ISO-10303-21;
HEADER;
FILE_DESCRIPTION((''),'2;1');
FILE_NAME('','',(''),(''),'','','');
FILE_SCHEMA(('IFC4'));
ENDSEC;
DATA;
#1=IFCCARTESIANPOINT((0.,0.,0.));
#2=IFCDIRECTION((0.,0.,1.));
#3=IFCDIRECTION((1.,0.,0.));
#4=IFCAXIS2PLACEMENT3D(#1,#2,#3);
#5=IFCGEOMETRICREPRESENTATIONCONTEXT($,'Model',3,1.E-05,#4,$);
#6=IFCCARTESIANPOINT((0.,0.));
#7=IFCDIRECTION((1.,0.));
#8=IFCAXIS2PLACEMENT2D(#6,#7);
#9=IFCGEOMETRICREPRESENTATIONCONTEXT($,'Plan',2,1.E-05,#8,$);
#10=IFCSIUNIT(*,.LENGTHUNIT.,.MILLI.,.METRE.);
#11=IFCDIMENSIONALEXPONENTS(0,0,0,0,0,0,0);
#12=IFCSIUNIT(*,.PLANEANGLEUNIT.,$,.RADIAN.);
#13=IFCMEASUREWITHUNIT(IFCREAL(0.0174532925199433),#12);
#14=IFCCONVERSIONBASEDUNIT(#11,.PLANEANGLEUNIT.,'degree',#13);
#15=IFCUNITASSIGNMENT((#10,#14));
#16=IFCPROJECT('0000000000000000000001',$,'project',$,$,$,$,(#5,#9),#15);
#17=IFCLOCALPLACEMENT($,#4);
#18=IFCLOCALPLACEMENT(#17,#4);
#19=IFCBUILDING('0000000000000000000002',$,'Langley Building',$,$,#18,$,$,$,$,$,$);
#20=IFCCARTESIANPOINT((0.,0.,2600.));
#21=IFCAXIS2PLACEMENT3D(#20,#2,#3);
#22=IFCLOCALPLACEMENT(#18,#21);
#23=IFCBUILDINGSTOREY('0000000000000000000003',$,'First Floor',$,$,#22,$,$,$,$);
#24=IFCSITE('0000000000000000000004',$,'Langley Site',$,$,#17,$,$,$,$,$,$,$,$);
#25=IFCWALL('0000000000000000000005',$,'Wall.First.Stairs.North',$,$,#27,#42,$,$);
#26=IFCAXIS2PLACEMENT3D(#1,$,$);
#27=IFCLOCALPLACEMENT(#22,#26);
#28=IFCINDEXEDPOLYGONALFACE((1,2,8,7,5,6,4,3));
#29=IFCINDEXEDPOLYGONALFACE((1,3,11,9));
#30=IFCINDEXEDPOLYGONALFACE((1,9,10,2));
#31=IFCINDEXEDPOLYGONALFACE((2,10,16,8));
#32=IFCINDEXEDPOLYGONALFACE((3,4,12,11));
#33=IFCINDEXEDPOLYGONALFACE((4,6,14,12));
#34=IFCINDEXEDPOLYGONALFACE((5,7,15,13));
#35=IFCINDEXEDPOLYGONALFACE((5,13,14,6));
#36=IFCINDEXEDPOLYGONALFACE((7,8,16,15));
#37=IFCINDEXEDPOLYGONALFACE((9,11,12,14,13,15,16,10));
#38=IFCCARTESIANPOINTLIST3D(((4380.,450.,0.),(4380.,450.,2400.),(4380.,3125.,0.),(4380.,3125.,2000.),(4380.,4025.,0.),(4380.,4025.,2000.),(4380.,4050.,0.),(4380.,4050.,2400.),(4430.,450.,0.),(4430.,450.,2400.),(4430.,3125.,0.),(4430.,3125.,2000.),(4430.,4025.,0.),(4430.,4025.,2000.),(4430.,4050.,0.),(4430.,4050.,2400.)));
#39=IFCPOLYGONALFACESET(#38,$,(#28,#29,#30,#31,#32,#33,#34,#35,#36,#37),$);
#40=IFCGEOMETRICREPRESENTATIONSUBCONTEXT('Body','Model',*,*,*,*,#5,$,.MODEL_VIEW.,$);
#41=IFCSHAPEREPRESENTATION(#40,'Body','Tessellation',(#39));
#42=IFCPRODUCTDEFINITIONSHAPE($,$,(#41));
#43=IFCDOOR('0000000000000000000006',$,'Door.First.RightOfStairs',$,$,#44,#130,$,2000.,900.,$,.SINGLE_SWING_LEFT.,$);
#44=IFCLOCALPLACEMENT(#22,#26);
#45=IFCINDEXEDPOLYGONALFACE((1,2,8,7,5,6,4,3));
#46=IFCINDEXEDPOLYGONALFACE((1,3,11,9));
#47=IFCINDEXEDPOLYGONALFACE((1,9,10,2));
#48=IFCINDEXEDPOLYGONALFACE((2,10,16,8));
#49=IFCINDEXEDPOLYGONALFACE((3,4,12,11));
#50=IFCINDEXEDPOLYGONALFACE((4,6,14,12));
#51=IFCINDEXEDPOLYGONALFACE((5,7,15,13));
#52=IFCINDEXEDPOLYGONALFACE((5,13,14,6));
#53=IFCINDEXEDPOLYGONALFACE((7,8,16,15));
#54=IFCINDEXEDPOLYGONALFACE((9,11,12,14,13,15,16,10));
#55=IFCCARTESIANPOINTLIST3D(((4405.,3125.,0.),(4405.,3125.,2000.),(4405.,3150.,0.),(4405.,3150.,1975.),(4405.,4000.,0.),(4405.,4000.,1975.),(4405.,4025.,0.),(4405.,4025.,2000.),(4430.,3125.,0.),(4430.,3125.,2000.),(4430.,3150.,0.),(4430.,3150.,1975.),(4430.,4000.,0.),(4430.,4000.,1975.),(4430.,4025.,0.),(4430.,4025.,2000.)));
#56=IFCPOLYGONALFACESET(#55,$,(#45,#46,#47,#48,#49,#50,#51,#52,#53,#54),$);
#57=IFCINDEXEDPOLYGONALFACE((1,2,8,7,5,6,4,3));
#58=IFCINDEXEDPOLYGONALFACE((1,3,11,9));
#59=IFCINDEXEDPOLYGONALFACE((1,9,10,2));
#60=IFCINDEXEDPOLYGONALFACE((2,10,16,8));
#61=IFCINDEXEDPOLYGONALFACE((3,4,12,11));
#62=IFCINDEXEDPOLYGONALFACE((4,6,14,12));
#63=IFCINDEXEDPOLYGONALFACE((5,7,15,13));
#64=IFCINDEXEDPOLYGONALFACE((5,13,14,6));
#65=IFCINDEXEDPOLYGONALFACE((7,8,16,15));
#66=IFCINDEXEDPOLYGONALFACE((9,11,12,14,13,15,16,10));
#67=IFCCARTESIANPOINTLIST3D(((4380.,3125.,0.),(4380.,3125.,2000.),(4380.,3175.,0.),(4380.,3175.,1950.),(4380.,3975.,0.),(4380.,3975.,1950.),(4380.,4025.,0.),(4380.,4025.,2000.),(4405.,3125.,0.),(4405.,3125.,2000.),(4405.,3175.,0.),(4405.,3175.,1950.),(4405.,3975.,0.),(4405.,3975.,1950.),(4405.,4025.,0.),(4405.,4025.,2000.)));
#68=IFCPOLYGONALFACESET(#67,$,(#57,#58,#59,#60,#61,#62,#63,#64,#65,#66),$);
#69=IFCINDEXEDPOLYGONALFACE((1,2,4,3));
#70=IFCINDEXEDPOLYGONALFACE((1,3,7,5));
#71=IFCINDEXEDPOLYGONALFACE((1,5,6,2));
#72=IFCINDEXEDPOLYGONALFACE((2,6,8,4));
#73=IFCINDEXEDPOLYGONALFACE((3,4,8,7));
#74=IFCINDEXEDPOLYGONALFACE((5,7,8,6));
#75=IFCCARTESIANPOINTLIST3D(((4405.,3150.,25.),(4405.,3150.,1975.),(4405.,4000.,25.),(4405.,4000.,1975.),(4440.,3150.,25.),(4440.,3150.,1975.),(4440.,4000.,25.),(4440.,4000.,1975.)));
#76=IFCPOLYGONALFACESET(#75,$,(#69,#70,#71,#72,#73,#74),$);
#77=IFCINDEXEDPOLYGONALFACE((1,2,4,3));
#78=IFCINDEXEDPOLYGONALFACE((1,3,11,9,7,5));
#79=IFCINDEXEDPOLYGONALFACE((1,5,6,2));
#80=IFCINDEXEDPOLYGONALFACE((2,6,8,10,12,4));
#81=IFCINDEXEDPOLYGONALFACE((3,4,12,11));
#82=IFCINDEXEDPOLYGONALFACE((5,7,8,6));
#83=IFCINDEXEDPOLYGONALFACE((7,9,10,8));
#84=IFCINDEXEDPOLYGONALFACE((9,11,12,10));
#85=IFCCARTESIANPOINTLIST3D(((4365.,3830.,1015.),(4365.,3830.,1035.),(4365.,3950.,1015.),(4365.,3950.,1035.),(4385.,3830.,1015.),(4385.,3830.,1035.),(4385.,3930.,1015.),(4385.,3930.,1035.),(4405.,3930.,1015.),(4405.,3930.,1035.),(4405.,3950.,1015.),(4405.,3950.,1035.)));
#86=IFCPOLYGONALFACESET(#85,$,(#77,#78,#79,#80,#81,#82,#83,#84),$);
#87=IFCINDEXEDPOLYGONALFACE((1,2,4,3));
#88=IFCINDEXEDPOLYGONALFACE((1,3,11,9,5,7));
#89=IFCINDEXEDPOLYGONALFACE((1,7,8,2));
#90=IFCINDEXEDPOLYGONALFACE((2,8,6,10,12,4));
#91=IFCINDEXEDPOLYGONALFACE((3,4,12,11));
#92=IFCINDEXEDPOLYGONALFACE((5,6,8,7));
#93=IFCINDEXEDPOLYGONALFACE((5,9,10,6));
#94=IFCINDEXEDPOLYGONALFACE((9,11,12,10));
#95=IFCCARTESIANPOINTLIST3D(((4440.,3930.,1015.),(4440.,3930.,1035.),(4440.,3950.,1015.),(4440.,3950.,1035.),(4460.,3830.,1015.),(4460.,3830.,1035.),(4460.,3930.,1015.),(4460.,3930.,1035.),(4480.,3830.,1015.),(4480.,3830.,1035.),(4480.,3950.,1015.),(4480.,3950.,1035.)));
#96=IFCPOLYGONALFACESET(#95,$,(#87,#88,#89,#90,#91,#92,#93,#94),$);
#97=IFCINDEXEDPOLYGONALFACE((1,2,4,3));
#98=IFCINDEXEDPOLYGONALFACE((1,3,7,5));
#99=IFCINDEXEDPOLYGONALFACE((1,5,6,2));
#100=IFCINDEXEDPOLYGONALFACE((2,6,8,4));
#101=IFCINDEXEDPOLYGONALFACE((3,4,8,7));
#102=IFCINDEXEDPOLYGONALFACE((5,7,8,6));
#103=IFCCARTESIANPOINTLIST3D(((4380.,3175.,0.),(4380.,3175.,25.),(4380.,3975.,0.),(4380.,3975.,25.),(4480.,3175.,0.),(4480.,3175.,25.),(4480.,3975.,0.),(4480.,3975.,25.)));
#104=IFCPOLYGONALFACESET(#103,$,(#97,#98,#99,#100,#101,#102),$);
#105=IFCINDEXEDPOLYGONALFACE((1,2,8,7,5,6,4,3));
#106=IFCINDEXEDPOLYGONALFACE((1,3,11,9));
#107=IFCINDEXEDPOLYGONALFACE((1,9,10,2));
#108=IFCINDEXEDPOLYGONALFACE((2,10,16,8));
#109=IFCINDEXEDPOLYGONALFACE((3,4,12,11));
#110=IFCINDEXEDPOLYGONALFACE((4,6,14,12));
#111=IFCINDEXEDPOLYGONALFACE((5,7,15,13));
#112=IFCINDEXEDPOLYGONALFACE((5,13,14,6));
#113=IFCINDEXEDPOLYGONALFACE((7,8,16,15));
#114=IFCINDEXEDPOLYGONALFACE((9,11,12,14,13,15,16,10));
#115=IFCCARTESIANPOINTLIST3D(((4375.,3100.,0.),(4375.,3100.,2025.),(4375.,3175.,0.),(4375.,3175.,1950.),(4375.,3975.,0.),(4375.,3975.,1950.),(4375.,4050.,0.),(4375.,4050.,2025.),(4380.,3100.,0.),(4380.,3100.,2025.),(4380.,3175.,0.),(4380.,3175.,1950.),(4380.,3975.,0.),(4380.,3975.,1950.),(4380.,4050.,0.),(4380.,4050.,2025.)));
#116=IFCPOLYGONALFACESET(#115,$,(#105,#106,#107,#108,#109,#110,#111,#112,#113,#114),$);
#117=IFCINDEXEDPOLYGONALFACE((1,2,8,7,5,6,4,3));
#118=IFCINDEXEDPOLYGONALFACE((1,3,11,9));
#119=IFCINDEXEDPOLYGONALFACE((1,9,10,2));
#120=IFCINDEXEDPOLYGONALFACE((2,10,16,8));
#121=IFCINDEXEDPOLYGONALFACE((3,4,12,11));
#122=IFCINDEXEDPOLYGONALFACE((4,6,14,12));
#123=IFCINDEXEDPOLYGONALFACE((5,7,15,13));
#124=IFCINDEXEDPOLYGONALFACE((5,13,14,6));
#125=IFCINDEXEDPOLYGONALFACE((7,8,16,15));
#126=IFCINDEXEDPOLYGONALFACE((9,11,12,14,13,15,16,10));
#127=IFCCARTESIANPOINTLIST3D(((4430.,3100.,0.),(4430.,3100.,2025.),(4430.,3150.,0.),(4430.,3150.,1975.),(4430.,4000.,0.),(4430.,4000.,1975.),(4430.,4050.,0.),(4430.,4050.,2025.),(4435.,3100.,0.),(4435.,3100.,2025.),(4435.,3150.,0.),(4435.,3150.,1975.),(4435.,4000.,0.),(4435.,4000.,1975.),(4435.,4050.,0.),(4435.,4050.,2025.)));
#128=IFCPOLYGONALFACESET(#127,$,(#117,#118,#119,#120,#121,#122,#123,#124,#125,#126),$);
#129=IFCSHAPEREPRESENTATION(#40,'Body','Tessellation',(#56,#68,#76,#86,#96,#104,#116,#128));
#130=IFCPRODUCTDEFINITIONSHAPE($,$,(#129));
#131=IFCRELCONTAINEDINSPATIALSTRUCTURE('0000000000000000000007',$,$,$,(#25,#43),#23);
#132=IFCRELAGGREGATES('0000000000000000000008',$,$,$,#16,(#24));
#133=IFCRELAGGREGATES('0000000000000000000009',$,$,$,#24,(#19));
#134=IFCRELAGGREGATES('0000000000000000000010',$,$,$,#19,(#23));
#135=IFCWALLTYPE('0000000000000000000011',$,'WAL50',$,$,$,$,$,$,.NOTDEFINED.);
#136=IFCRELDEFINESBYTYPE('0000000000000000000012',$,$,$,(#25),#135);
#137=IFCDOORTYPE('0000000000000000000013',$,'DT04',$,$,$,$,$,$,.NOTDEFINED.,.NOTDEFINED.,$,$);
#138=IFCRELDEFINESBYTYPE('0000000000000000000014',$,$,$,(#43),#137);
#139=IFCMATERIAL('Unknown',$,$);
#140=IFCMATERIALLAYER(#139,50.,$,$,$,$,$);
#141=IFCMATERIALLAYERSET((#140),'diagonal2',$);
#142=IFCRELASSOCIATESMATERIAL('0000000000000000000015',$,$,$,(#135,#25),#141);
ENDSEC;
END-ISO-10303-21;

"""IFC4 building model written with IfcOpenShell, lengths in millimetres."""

from ifc_helpers import new_model, entity, si_unit, converted_unit, frame, origin_with_axes, origin_2d_with_axis, place, context, subcontext, project, spatial, line, indexed_curve, outline, extrude, shape, source, transform, mapped, material, layer, layer_set, layer_usage, type_object, type_shapes, element, fill, save


model = new_model("IFC4")

# Units and contexts
model_context = context("Model", 3, precision=1e-05, world=origin_with_axes())
plan_context = context("Plan", 2, precision=1e-05, world=origin_2d_with_axis())
body_context_1 = subcontext(model_context, "Body", "Model", "MODEL_VIEW")
body_context_2 = subcontext(plan_context, "Body", "Plan", "PLAN_VIEW")
ifc_project = project(units=[si_unit("LENGTHUNIT", "METRE", prefix="MILLI"), converted_unit("PLANEANGLEUNIT", "degree", entity("IfcReal", 0.0174532925199433), si_unit("PLANEANGLEUNIT", "RADIAN"), dimensions=[0, 0, 0, 0, 0, 0, 0])], contexts=[model_context, plan_context])

# Site, building, storey
site_placement = place(None, origin_with_axes())
site = spatial("IfcSite", under=ifc_project, at=site_placement, Name="Langley Site")
building_placement = place(site_placement, origin_with_axes())
building = spatial("IfcBuilding", under=site, at=building_placement, Name="Langley Building")
storey_placement = place(building_placement, frame((0.0, 0.0, 2600.0), z_axis=(0.0, 0.0, 1.0), x_axis=(1.0, 0.0, 0.0)))
storey = spatial("IfcBuildingStorey", under=building, at=storey_placement, Name="First Floor")

# Wall, opening, door
ifc_material = material(Name="Unknown")
ifc_layer_1 = layer(ifc_material, 50.0)
ifc_layer_set_1 = layer_set([ifc_layer_1], Name="diagonal2")
ifc_layer_usage_1 = layer_usage(ifc_layer_set_1, "AXIS2", "POSITIVE", 0.0)
wall_type_1 = type_object("IfcWallType", Name="WAL50", PredefinedType="NOTDEFINED", material=ifc_layer_set_1)
wall_1_placement = place(storey_placement, frame((4380.0, 4050.0, 0.0), z_axis=(0.0, 0.0, 1.0), x_axis=(0.0, -1.0, 0.0)))
wall_1 = element("IfcWall", 1, at=wall_1_placement, inside=storey, type_object=wall_type_1, material=ifc_layer_usage_1, Name="Wall.First.Stairs.North", context=body_context_1, shape_type="SweptSolid", body=[
    extrude(outline(indexed_curve([(0.0, 0.0), (0.0, 50.0), (3600.0, 50.0), (3600.0, 0.0)], segments=[line(1, 2, 3, 4, 1)])), origin_with_axes(), (0.0, 0.0, 1.0), 2400.0),
])
shared_shape_1 = source(origin_with_axes(), body_context_1, "Body", "SweptSolid", [
    extrude(outline(indexed_curve([(0.0, 0.0), (900.0, 0.0), (900.0, 2000.0), (0.0, 2000.0)], segments=[line(1, 2, 3, 4, 1)])), frame((0.0, -600.0, 0.0), z_axis=(0.0, -1.0, 0.0), x_axis=(1.0, 0.0, 0.0)), (0.0, 0.0, -1.0), 1200.0),
])
opening_1_placement = place(wall_1_placement, frame((25.0, 0.0, 0.0), z_axis=(0.0, 0.0, 1.0), x_axis=(1.0, 0.0, 0.0)))
opening_1 = element("IfcOpeningElement", 2, at=opening_1_placement, cuts=wall_1, PredefinedType="OPENING", context=body_context_1, shape_type="MappedRepresentation", body=[
    mapped(shared_shape_1, transform((0.0, 0.0, 0.0), x_axis=(1.0, 0.0, 0.0), y_axis=(0.0, 1.0, 0.0), z_axis=(0.0, 0.0, 1.0), scale=1.0)),
])
door_type_1 = type_object("IfcDoorType", Name="DT04", OperationType="NOTDEFINED", PredefinedType="NOTDEFINED")
shared_shape_2 = source(origin_with_axes(), body_context_1, "Body", "SweptSolid", [
    extrude(outline(indexed_curve([(0.0, 0.0), (0.0, 2000.0), (900.0, 2000.0), (900.0, 0.0), (875.0, 0.0), (875.0, 1975.0), (25.0, 1975.0), (25.0, 0.0)], segments=[line(1, 2, 3, 4, 5, 6, 7, 8, 1)])), frame((0.0, 25.0, 0.0), z_axis=(0.0, -1.0, 0.0), x_axis=(1.0, 0.0, 0.0)), (0.0, 0.0, -1.0), 25.0),
    extrude(outline(indexed_curve([(0.0, 0.0), (0.0, 2000.0), (900.0, 2000.0), (900.0, 0.0), (850.0, 0.0), (850.0, 1950.0), (50.0, 1950.0), (50.0, 0.0)], segments=[line(1, 2, 3, 4, 5, 6, 7, 8, 1)])), frame((0.0, 0.0, 0.0), z_axis=(0.0, -1.0, 0.0), x_axis=(1.0, 0.0, 0.0)), (0.0, 0.0, -1.0), 25.0),
    extrude(outline(indexed_curve([(0.0, 0.0), (850.0, 0.0), (850.0, 35.0), (0.0, 35.0)], segments=[line(1, 2, 3, 4, 1)])), frame((25.0, 25.0, 25.0), z_axis=(0.0, 0.0, 1.0), x_axis=(1.0, 0.0, 0.0)), (0.0, 0.0, 1.0), 1950.0),
    extrude(outline(indexed_curve([(0.0, 0.0), (0.0, -40.0), (120.0, -40.0), (120.0, -20.0), (20.0, -20.0), (20.0, 0.0)], segments=[line(1, 2, 3, 4, 5, 6, 1)])), frame((75.0, 25.0, 1015.0), z_axis=(0.0, 0.0, 1.0), x_axis=(1.0, 0.0, 0.0)), (0.0, 0.0, 1.0), 20.0),
    extrude(outline(indexed_curve([(0.0, 0.0), (0.0, 40.0), (120.0, 40.0), (120.0, 20.0), (20.0, 20.0), (20.0, 0.0)], segments=[line(1, 2, 3, 4, 5, 6, 1)])), frame((75.0, 60.0, 1015.0), z_axis=(0.0, 0.0, 1.0), x_axis=(1.0, 0.0, 0.0)), (0.0, 0.0, 1.0), 20.0),
    extrude(outline(indexed_curve([(0.0, 0.0), (800.0, 0.0), (800.0, 100.0), (0.0, 100.0)], segments=[line(1, 2, 3, 4, 1)])), frame((50.0, 0.0, 0.0), z_axis=(0.0, 0.0, 1.0), x_axis=(1.0, 0.0, 0.0)), (0.0, 0.0, 1.0), 25.0),
    extrude(outline(indexed_curve([(0.0, 0.0), (0.0, 2025.0), (950.0, 2025.0), (950.0, 0.0), (875.0, 0.0), (875.0, 1950.0), (75.0, 1950.0), (75.0, 0.0)], segments=[line(1, 2, 3, 4, 5, 6, 7, 8, 1)])), frame((-25.0, -5.0, 0.0), z_axis=(0.0, -1.0, 0.0), x_axis=(1.0, 0.0, 0.0)), (0.0, 0.0, -1.0), 5.0),
    extrude(outline(indexed_curve([(0.0, 0.0), (0.0, 2025.0), (950.0, 2025.0), (950.0, 0.0), (900.0, 0.0), (900.0, 1975.0), (50.0, 1975.0), (50.0, 0.0)], segments=[line(1, 2, 3, 4, 5, 6, 7, 8, 1)])), frame((-25.0, 50.0, 0.0), z_axis=(0.0, -1.0, 0.0), x_axis=(1.0, 0.0, 0.0)), (0.0, 0.0, -1.0), 5.0),
])
shared_shape_3 = source(origin_with_axes(), body_context_2, "Body", "Curve2D", [
    entity("IfcIndexedPolyCurve", entity("IfcCartesianPointList2D", [[0.0, 0.0], [0.0, 50.0], [25.0, 50.0], [25.0, 25.0], [50.0, 25.0], [50.0, 0.0]]), [entity("IfcLineIndex", [1, 2, 3, 4, 5, 6, 1])]),
    entity("IfcIndexedPolyCurve", entity("IfcCartesianPointList2D", [[900.0, 0.0], [900.0, 50.0], [875.0, 50.0], [875.0, 25.0], [850.0, 25.0], [850.0, 0.0]]), [entity("IfcLineIndex", [1, 2, 3, 4, 5, 6, 1])]),
    entity("IfcTrimmedCurve", entity("IfcEllipse", entity("IfcAxis2Placement2D", entity("IfcCartesianPoint", [840.0, 50.0]), entity("IfcDirection", [1.0, 0.0])), 815.0, 850.0), [entity("IfcCartesianPoint", [840.0, 900.0])], [entity("IfcCartesianPoint", [25.0, 50.0])], True, "CARTESIAN"),
    entity("IfcIndexedPolyCurve", entity("IfcCartesianPointList2D", [[875.0, 50.0], [840.0, 50.0], [840.0, 900.0], [875.0, 900.0]]), [entity("IfcLineIndex", [1, 2, 3, 4, 1])]),
])
type_shapes(door_type_1, [shared_shape_2, shared_shape_3])
door_1_placement = place(opening_1_placement, frame((0.0, 0.0, 0.0), z_axis=(0.0, 0.0, 1.0), x_axis=(1.0, -0.000001, 0.0)))
door_1 = element("IfcDoor", 3, at=door_1_placement, inside=storey, type_object=door_type_1, Name="Door.First.RightOfStairs", OperationType="SINGLE_SWING_LEFT", OverallHeight=2000.0, OverallWidth=900.0, shapes=[
    shape(body_context_1, "Body", "MappedRepresentation", [mapped(shared_shape_2, transform((0.0, 0.0, 0.0), x_axis=(1.0, 0.0, 0.0), y_axis=(0.0, 1.0, 0.0), z_axis=(0.0, 0.0, 1.0), scale=1.0))]),
    shape(body_context_2, "Body", "MappedRepresentation", [mapped(shared_shape_3, transform((0.0, 0.0, 0.0), x_axis=(1.0, 0.0, 0.0), y_axis=(0.0, 1.0, 0.0), z_axis=(0.0, 0.0, 1.0), scale=1.0))]),
])
fill(opening_1, door_1)

save(model, "model.ifc")
